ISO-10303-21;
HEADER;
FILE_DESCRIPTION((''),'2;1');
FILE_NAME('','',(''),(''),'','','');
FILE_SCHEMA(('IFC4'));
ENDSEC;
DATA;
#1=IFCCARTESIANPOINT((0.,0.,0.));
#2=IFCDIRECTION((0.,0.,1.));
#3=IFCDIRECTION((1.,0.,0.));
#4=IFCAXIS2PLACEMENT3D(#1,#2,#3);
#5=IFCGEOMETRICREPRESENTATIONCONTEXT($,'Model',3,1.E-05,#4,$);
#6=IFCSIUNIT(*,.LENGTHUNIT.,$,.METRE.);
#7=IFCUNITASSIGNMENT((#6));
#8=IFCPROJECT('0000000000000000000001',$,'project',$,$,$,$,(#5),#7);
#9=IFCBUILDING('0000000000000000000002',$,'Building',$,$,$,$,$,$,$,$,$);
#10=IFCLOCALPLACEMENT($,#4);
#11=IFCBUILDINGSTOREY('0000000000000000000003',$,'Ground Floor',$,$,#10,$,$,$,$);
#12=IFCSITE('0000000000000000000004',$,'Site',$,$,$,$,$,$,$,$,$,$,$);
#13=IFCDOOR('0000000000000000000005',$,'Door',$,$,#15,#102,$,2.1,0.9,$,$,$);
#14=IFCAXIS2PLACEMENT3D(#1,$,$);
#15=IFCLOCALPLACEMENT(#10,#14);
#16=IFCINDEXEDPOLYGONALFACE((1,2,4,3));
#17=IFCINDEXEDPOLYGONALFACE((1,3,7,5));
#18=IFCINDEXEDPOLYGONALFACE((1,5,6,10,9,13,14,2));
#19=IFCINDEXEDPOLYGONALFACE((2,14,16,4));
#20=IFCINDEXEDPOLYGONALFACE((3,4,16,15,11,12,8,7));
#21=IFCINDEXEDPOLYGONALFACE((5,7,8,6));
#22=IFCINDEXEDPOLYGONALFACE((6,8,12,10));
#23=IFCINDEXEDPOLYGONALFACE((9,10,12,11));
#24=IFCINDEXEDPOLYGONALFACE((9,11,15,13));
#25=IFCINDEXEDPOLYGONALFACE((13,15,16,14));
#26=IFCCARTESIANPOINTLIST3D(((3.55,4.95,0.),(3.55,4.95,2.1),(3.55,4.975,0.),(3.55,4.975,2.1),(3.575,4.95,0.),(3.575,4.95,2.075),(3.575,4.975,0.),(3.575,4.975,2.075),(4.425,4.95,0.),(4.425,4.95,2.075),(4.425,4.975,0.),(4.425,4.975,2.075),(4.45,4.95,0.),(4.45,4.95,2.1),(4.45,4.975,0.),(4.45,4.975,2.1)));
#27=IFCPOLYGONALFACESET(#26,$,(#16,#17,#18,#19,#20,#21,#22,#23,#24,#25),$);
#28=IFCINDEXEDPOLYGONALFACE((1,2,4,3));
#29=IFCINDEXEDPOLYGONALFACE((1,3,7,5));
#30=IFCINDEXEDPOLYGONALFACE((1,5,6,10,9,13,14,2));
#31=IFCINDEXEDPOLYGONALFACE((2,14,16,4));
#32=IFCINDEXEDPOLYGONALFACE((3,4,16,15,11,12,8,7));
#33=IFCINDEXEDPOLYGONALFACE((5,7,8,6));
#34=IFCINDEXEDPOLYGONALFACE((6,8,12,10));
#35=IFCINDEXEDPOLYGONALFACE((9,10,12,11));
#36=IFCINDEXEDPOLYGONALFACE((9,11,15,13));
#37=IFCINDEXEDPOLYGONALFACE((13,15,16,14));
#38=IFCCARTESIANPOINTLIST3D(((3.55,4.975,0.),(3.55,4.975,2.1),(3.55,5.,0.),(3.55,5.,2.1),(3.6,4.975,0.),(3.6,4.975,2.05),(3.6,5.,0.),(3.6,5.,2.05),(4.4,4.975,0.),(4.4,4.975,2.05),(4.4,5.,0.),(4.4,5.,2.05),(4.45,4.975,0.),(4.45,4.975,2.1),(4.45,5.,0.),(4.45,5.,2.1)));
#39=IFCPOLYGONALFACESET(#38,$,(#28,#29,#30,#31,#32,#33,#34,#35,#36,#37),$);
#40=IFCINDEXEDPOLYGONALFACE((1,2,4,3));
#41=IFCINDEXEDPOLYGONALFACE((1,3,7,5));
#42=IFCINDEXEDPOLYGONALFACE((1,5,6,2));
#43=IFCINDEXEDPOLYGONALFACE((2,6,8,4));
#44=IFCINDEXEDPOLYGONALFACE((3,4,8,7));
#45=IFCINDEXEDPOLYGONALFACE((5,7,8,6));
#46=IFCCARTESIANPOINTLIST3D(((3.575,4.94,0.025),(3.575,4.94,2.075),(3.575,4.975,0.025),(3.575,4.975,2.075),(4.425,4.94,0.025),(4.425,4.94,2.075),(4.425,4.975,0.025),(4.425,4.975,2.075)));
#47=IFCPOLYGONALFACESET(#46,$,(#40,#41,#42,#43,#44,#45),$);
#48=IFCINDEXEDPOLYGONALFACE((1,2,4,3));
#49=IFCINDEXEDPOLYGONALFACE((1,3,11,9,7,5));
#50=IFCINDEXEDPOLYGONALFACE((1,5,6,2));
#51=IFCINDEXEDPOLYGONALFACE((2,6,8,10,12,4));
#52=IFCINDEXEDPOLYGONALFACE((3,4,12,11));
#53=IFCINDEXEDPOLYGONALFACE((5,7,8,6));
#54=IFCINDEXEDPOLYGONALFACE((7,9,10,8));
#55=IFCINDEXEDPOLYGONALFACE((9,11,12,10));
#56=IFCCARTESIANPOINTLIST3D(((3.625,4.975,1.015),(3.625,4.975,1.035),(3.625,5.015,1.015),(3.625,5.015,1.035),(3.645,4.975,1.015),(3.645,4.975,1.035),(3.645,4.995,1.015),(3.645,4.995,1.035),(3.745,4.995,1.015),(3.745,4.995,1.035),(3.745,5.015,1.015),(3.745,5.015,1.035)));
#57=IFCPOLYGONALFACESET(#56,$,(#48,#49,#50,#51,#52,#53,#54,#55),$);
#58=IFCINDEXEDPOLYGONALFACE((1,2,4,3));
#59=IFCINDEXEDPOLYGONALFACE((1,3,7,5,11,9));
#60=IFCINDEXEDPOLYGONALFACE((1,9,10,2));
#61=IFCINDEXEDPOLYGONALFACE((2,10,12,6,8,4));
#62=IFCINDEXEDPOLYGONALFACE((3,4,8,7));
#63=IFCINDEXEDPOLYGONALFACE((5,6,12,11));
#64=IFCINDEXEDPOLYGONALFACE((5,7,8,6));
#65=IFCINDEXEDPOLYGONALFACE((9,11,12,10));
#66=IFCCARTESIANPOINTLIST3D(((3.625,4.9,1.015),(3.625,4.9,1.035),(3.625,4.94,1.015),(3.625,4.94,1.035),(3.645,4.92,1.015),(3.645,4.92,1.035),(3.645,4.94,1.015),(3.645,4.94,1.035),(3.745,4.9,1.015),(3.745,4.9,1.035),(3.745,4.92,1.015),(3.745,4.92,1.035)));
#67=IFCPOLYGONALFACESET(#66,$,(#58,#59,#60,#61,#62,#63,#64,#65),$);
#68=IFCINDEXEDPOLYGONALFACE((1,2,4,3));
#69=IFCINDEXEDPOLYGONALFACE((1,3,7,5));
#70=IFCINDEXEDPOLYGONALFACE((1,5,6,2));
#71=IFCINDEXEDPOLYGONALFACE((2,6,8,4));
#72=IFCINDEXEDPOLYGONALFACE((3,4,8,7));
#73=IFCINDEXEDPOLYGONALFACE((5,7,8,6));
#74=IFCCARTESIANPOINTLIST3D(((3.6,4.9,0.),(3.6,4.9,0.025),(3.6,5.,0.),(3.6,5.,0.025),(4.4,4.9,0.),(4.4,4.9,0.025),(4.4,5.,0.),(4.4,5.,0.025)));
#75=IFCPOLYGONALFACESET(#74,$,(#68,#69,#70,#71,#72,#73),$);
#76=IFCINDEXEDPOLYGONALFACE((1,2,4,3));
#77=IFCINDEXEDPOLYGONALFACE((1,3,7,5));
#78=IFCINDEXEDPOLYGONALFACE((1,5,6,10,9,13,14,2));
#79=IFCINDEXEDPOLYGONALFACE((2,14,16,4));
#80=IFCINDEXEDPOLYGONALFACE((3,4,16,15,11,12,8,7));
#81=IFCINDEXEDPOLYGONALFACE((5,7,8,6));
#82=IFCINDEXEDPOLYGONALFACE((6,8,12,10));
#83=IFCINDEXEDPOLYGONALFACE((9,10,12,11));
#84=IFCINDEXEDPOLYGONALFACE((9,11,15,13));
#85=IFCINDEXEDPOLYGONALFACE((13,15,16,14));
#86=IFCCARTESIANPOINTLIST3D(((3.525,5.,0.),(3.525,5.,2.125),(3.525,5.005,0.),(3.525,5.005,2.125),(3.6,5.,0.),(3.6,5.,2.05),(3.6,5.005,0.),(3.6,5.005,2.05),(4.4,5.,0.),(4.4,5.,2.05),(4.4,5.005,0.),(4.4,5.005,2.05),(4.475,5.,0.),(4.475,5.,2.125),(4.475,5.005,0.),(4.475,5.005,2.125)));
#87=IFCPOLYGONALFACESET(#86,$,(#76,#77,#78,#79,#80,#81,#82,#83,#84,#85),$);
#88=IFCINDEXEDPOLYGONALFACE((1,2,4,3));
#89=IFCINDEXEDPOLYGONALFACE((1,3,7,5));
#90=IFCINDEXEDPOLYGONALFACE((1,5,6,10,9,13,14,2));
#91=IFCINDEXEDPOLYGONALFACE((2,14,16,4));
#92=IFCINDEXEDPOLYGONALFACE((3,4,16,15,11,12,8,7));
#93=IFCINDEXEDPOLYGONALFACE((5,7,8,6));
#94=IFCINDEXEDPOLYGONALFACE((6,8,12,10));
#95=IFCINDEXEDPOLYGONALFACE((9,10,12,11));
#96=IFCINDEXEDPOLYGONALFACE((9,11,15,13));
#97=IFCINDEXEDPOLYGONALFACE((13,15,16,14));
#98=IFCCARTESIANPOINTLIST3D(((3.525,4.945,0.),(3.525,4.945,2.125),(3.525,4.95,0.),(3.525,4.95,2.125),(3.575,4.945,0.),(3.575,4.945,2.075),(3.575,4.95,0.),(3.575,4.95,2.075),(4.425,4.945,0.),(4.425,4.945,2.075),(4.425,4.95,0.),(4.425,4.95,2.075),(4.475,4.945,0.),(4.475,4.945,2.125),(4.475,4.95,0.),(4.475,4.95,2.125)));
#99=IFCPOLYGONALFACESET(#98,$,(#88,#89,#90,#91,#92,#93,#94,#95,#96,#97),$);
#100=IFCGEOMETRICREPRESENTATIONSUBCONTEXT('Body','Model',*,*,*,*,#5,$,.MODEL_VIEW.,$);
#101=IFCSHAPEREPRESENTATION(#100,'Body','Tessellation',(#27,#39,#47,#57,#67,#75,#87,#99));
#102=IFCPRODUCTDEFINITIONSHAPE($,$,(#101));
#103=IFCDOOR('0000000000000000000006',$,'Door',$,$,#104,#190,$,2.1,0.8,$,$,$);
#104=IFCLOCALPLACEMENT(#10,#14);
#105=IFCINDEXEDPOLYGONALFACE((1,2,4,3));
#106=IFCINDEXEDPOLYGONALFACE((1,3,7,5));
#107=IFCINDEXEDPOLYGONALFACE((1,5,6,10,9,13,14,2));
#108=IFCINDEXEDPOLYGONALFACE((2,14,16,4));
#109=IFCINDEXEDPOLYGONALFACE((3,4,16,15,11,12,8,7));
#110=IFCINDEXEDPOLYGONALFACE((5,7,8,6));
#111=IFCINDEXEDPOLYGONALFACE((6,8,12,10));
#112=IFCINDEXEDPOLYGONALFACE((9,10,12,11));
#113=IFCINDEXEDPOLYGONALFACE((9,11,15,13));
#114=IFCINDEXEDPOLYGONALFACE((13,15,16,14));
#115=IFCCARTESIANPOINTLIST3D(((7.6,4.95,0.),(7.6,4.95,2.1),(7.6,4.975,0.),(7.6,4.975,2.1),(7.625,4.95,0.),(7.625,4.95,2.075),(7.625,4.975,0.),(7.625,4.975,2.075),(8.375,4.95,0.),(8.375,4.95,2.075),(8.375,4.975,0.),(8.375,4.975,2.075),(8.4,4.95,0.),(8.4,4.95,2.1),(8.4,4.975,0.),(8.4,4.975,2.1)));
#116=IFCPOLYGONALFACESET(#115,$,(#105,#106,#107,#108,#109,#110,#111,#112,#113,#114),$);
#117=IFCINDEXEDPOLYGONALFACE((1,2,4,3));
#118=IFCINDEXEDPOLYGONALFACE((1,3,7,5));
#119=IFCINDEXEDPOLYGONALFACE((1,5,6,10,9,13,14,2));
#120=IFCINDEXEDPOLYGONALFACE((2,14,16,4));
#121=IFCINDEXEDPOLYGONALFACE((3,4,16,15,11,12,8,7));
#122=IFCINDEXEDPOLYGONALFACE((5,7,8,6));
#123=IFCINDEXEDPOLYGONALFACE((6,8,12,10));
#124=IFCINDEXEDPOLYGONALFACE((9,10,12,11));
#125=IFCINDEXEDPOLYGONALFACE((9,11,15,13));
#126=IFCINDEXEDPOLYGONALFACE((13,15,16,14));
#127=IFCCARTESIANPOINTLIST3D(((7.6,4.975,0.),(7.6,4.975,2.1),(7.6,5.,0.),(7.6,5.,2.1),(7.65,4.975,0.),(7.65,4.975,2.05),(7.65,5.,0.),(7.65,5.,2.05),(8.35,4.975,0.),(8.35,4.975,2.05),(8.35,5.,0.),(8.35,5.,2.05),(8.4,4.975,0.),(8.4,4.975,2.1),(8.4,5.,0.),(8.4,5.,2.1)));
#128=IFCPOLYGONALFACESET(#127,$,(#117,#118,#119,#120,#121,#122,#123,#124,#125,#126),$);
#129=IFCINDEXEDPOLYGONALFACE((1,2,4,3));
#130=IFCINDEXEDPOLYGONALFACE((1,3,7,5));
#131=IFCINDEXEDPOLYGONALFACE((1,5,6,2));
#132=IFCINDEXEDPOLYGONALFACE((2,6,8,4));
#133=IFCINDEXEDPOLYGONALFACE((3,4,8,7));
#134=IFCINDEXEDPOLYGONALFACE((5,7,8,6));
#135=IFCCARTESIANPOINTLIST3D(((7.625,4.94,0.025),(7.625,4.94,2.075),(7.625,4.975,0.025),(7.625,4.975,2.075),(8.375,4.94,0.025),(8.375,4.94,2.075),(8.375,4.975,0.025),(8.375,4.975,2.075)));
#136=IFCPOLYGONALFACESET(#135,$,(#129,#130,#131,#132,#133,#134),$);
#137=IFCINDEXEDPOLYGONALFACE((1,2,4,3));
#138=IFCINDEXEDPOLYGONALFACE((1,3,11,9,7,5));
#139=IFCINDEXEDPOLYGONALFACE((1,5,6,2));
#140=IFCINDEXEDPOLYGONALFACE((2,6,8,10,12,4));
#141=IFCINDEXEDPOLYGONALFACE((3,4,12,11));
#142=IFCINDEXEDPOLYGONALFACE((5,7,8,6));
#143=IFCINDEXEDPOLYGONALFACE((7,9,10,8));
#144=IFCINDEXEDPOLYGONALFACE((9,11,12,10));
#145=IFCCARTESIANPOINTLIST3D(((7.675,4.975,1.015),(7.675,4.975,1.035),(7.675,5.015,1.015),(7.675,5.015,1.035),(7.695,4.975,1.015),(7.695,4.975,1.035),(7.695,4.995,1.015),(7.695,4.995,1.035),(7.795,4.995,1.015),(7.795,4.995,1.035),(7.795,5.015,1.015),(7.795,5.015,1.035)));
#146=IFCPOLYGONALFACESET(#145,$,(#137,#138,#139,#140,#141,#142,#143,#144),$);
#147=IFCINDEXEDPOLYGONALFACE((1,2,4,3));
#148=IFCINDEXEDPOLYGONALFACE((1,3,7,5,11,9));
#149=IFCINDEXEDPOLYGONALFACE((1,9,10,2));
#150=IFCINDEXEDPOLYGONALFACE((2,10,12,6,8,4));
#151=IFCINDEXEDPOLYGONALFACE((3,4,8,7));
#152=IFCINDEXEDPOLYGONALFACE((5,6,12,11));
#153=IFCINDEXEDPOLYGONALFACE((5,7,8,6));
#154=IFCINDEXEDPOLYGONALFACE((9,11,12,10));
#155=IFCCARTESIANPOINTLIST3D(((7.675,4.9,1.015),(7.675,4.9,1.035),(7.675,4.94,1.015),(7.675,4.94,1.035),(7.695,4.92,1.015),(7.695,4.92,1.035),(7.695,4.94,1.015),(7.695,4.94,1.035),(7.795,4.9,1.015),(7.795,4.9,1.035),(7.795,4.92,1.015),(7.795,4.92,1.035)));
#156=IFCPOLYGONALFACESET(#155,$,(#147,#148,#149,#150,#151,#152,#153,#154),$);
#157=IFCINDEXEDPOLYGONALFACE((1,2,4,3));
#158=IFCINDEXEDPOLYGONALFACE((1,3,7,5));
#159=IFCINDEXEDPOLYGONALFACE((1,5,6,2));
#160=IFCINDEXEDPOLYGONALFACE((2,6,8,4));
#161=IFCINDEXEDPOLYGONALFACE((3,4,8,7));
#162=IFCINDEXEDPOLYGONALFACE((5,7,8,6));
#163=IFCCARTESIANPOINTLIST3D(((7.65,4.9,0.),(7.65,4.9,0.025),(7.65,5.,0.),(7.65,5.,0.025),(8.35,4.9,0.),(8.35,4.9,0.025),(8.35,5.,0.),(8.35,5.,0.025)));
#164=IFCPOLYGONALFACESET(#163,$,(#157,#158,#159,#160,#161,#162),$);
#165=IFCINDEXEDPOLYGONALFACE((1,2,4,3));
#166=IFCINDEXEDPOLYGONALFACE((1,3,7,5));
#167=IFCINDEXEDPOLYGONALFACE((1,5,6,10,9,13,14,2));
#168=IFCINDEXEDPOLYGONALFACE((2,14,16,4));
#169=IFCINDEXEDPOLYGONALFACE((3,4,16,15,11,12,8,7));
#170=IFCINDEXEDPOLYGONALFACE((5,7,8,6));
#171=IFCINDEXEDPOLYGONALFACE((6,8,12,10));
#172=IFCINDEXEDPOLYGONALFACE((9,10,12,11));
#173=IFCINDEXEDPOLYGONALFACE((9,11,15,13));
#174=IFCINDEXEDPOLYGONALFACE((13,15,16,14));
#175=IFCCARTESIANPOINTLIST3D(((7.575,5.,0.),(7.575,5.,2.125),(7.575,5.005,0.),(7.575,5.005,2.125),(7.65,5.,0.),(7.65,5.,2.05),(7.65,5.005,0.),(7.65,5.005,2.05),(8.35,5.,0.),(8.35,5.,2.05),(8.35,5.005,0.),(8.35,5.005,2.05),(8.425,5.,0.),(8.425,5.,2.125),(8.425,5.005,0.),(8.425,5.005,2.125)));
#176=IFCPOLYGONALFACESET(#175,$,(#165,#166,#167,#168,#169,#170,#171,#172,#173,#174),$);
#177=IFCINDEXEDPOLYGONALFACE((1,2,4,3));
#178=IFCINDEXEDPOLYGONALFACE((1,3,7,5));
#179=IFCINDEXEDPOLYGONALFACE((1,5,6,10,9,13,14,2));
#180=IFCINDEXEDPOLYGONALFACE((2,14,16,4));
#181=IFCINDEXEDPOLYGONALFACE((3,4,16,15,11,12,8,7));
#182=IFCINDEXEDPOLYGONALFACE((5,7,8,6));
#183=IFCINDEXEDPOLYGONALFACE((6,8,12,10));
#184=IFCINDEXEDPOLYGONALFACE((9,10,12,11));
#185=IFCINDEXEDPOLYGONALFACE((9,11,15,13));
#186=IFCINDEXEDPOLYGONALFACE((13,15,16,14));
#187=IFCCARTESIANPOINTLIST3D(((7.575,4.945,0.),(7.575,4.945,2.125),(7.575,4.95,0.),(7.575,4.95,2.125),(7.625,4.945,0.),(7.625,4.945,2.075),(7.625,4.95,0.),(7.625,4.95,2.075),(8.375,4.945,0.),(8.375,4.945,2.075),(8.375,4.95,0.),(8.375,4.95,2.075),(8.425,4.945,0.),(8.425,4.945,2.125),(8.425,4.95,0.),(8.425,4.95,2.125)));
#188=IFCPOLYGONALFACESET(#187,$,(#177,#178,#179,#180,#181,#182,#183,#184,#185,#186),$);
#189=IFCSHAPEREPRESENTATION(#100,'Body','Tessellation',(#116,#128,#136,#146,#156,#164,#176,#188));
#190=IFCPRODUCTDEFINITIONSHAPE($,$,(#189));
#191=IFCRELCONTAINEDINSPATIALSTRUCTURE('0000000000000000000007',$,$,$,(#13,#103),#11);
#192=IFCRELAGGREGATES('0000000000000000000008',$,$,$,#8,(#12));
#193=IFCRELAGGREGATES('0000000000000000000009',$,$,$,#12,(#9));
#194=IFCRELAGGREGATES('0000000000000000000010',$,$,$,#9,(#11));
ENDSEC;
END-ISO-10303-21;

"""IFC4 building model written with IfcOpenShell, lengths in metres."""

from ifc_helpers import new_model, si_unit, frame, origin_with_axes, place, context, subcontext, project, spatial, line, indexed_curve, outline, extrude, element, save


model = new_model("IFC4")

# Units and contexts
model_context = context("Model", 3, precision=1e-05, world=origin_with_axes())
body_context = subcontext(model_context, "Body", "Model", "MODEL_VIEW")
ifc_project = project(units=[si_unit("LENGTHUNIT", "METRE")], contexts=[model_context])

# Site, building, storey
site = spatial("IfcSite", under=ifc_project, Name="Site")
building = spatial("IfcBuilding", under=site, Name="Building")
storey_placement = place(None, origin_with_axes())
storey = spatial("IfcBuildingStorey", under=building, at=storey_placement, Name="Ground Floor")

# Doors
door_1_placement = place(storey_placement, frame((4.45, 5.0, 0.0), z_axis=(0.0, 0.0, 1.0), x_axis=(-1.0, 0.0, 0.0)))
element("IfcDoor", 1, at=door_1_placement, inside=storey, Name="Door", OverallHeight=2.1, OverallWidth=0.9, context=body_context, shape_type="SweptSolid", body=[
    extrude(outline(indexed_curve([(0.0, 0.0), (0.0, 2.1), (0.9, 2.1), (0.9, 0.0), (0.875, 0.0), (0.875, 2.075), (0.025, 2.075), (0.025, 0.0)], segments=[line(1, 2, 3, 4, 5, 6, 7, 8, 1)])), frame((0.0, 0.025, 0.0), z_axis=(0.0, -1.0, 0.0), x_axis=(1.0, 0.0, 0.0)), (0.0, 0.0, -1.0), 0.025),
    extrude(outline(indexed_curve([(0.0, 0.0), (0.0, 2.1), (0.9, 2.1), (0.9, 0.0), (0.85, 0.0), (0.85, 2.05), (0.05, 2.05), (0.05, 0.0)], segments=[line(1, 2, 3, 4, 5, 6, 7, 8, 1)])), frame((0.0, 0.0, 0.0), z_axis=(0.0, -1.0, 0.0), x_axis=(1.0, 0.0, 0.0)), (0.0, 0.0, -1.0), 0.025),
    extrude(outline(indexed_curve([(0.0, 0.0), (0.85, 0.0), (0.85, 0.035), (0.0, 0.035)], segments=[line(1, 2, 3, 4, 1)])), frame((0.025, 0.025, 0.025), z_axis=(0.0, 0.0, 1.0), x_axis=(1.0, 0.0, 0.0)), (0.0, 0.0, 1.0), 2.05),
    extrude(outline(indexed_curve([(0.0, 0.0), (0.0, -0.04), (-0.12, -0.04), (-0.12, -0.02), (-0.02, -0.02), (-0.02, 0.0)], segments=[line(1, 2, 3, 4, 5, 6, 1)])), frame((0.825, 0.025, 1.015), z_axis=(0.0, 0.0, 1.0), x_axis=(1.0, 0.0, 0.0)), (0.0, 0.0, 1.0), 0.02),
    extrude(outline(indexed_curve([(0.0, 0.0), (0.0, 0.04), (-0.12, 0.04), (-0.12, 0.02), (-0.02, 0.02), (-0.02, 0.0)], segments=[line(1, 2, 3, 4, 5, 6, 1)])), frame((0.825, 0.06, 1.015), z_axis=(0.0, 0.0, 1.0), x_axis=(1.0, 0.0, 0.0)), (0.0, 0.0, 1.0), 0.02),
    extrude(outline(indexed_curve([(0.0, 0.0), (0.8, 0.0), (0.8, 0.1), (0.0, 0.1)], segments=[line(1, 2, 3, 4, 1)])), frame((0.05, 0.0, 0.0), z_axis=(0.0, 0.0, 1.0), x_axis=(1.0, 0.0, 0.0)), (0.0, 0.0, 1.0), 0.025),
    extrude(outline(indexed_curve([(0.0, 0.0), (0.0, 2.125), (0.95, 2.125), (0.95, 0.0), (0.875, 0.0), (0.875, 2.05), (0.075, 2.05), (0.075, 0.0)], segments=[line(1, 2, 3, 4, 5, 6, 7, 8, 1)])), frame((-0.025, -0.005, 0.0), z_axis=(0.0, -1.0, 0.0), x_axis=(1.0, 0.0, 0.0)), (0.0, 0.0, -1.0), 0.005),
    extrude(outline(indexed_curve([(0.0, 0.0), (0.0, 2.125), (0.95, 2.125), (0.95, 0.0), (0.9, 0.0), (0.9, 2.075), (0.05, 2.075), (0.05, 0.0)], segments=[line(1, 2, 3, 4, 5, 6, 7, 8, 1)])), frame((-0.025, 0.05, 0.0), z_axis=(0.0, -1.0, 0.0), x_axis=(1.0, 0.0, 0.0)), (0.0, 0.0, -1.0), 0.005),
])
door_2_placement = place(storey_placement, frame((8.4, 5.0, 0.0), z_axis=(0.0, 0.0, 1.0), x_axis=(-1.0, 0.0, 0.0)))
element("IfcDoor", 2, at=door_2_placement, inside=storey, Name="Door", OverallHeight=2.1, OverallWidth=0.8, context=body_context, shape_type="SweptSolid", body=[
    extrude(outline(indexed_curve([(0.0, 0.0), (0.0, 2.1), (0.8, 2.1), (0.8, 0.0), (0.775, 0.0), (0.775, 2.075), (0.025, 2.075), (0.025, 0.0)], segments=[line(1, 2, 3, 4, 5, 6, 7, 8, 1)])), frame((0.0, 0.025, 0.0), z_axis=(0.0, -1.0, 0.0), x_axis=(1.0, 0.0, 0.0)), (0.0, 0.0, -1.0), 0.025),
    extrude(outline(indexed_curve([(0.0, 0.0), (0.0, 2.1), (0.8, 2.1), (0.8, 0.0), (0.75, 0.0), (0.75, 2.05), (0.05, 2.05), (0.05, 0.0)], segments=[line(1, 2, 3, 4, 5, 6, 7, 8, 1)])), frame((0.0, 0.0, 0.0), z_axis=(0.0, -1.0, 0.0), x_axis=(1.0, 0.0, 0.0)), (0.0, 0.0, -1.0), 0.025),
    extrude(outline(indexed_curve([(0.0, 0.0), (0.75, 0.0), (0.75, 0.035), (0.0, 0.035)], segments=[line(1, 2, 3, 4, 1)])), frame((0.025, 0.025, 0.025), z_axis=(0.0, 0.0, 1.0), x_axis=(1.0, 0.0, 0.0)), (0.0, 0.0, 1.0), 2.05),
    extrude(outline(indexed_curve([(0.0, 0.0), (0.0, -0.04), (-0.12, -0.04), (-0.12, -0.02), (-0.02, -0.02), (-0.02, 0.0)], segments=[line(1, 2, 3, 4, 5, 6, 1)])), frame((0.725, 0.025, 1.015), z_axis=(0.0, 0.0, 1.0), x_axis=(1.0, 0.0, 0.0)), (0.0, 0.0, 1.0), 0.02),
    extrude(outline(indexed_curve([(0.0, 0.0), (0.0, 0.04), (-0.12, 0.04), (-0.12, 0.02), (-0.02, 0.02), (-0.02, 0.0)], segments=[line(1, 2, 3, 4, 5, 6, 1)])), frame((0.725, 0.06, 1.015), z_axis=(0.0, 0.0, 1.0), x_axis=(1.0, 0.0, 0.0)), (0.0, 0.0, 1.0), 0.02),
    extrude(outline(indexed_curve([(0.0, 0.0), (0.7, 0.0), (0.7, 0.1), (0.0, 0.1)], segments=[line(1, 2, 3, 4, 1)])), frame((0.05, 0.0, 0.0), z_axis=(0.0, 0.0, 1.0), x_axis=(1.0, 0.0, 0.0)), (0.0, 0.0, 1.0), 0.025),
    extrude(outline(indexed_curve([(0.0, 0.0), (0.0, 2.125), (0.85, 2.125), (0.85, 0.0), (0.775, 0.0), (0.775, 2.05), (0.075, 2.05), (0.075, 0.0)], segments=[line(1, 2, 3, 4, 5, 6, 7, 8, 1)])), frame((-0.025, -0.005, 0.0), z_axis=(0.0, -1.0, 0.0), x_axis=(1.0, 0.0, 0.0)), (0.0, 0.0, -1.0), 0.005),
    extrude(outline(indexed_curve([(0.0, 0.0), (0.0, 2.125), (0.85, 2.125), (0.85, 0.0), (0.8, 0.0), (0.8, 2.075), (0.05, 2.075), (0.05, 0.0)], segments=[line(1, 2, 3, 4, 5, 6, 7, 8, 1)])), frame((-0.025, 0.05, 0.0), z_axis=(0.0, -1.0, 0.0), x_axis=(1.0, 0.0, 0.0)), (0.0, 0.0, -1.0), 0.005),
])

save(model, "model.ifc")
